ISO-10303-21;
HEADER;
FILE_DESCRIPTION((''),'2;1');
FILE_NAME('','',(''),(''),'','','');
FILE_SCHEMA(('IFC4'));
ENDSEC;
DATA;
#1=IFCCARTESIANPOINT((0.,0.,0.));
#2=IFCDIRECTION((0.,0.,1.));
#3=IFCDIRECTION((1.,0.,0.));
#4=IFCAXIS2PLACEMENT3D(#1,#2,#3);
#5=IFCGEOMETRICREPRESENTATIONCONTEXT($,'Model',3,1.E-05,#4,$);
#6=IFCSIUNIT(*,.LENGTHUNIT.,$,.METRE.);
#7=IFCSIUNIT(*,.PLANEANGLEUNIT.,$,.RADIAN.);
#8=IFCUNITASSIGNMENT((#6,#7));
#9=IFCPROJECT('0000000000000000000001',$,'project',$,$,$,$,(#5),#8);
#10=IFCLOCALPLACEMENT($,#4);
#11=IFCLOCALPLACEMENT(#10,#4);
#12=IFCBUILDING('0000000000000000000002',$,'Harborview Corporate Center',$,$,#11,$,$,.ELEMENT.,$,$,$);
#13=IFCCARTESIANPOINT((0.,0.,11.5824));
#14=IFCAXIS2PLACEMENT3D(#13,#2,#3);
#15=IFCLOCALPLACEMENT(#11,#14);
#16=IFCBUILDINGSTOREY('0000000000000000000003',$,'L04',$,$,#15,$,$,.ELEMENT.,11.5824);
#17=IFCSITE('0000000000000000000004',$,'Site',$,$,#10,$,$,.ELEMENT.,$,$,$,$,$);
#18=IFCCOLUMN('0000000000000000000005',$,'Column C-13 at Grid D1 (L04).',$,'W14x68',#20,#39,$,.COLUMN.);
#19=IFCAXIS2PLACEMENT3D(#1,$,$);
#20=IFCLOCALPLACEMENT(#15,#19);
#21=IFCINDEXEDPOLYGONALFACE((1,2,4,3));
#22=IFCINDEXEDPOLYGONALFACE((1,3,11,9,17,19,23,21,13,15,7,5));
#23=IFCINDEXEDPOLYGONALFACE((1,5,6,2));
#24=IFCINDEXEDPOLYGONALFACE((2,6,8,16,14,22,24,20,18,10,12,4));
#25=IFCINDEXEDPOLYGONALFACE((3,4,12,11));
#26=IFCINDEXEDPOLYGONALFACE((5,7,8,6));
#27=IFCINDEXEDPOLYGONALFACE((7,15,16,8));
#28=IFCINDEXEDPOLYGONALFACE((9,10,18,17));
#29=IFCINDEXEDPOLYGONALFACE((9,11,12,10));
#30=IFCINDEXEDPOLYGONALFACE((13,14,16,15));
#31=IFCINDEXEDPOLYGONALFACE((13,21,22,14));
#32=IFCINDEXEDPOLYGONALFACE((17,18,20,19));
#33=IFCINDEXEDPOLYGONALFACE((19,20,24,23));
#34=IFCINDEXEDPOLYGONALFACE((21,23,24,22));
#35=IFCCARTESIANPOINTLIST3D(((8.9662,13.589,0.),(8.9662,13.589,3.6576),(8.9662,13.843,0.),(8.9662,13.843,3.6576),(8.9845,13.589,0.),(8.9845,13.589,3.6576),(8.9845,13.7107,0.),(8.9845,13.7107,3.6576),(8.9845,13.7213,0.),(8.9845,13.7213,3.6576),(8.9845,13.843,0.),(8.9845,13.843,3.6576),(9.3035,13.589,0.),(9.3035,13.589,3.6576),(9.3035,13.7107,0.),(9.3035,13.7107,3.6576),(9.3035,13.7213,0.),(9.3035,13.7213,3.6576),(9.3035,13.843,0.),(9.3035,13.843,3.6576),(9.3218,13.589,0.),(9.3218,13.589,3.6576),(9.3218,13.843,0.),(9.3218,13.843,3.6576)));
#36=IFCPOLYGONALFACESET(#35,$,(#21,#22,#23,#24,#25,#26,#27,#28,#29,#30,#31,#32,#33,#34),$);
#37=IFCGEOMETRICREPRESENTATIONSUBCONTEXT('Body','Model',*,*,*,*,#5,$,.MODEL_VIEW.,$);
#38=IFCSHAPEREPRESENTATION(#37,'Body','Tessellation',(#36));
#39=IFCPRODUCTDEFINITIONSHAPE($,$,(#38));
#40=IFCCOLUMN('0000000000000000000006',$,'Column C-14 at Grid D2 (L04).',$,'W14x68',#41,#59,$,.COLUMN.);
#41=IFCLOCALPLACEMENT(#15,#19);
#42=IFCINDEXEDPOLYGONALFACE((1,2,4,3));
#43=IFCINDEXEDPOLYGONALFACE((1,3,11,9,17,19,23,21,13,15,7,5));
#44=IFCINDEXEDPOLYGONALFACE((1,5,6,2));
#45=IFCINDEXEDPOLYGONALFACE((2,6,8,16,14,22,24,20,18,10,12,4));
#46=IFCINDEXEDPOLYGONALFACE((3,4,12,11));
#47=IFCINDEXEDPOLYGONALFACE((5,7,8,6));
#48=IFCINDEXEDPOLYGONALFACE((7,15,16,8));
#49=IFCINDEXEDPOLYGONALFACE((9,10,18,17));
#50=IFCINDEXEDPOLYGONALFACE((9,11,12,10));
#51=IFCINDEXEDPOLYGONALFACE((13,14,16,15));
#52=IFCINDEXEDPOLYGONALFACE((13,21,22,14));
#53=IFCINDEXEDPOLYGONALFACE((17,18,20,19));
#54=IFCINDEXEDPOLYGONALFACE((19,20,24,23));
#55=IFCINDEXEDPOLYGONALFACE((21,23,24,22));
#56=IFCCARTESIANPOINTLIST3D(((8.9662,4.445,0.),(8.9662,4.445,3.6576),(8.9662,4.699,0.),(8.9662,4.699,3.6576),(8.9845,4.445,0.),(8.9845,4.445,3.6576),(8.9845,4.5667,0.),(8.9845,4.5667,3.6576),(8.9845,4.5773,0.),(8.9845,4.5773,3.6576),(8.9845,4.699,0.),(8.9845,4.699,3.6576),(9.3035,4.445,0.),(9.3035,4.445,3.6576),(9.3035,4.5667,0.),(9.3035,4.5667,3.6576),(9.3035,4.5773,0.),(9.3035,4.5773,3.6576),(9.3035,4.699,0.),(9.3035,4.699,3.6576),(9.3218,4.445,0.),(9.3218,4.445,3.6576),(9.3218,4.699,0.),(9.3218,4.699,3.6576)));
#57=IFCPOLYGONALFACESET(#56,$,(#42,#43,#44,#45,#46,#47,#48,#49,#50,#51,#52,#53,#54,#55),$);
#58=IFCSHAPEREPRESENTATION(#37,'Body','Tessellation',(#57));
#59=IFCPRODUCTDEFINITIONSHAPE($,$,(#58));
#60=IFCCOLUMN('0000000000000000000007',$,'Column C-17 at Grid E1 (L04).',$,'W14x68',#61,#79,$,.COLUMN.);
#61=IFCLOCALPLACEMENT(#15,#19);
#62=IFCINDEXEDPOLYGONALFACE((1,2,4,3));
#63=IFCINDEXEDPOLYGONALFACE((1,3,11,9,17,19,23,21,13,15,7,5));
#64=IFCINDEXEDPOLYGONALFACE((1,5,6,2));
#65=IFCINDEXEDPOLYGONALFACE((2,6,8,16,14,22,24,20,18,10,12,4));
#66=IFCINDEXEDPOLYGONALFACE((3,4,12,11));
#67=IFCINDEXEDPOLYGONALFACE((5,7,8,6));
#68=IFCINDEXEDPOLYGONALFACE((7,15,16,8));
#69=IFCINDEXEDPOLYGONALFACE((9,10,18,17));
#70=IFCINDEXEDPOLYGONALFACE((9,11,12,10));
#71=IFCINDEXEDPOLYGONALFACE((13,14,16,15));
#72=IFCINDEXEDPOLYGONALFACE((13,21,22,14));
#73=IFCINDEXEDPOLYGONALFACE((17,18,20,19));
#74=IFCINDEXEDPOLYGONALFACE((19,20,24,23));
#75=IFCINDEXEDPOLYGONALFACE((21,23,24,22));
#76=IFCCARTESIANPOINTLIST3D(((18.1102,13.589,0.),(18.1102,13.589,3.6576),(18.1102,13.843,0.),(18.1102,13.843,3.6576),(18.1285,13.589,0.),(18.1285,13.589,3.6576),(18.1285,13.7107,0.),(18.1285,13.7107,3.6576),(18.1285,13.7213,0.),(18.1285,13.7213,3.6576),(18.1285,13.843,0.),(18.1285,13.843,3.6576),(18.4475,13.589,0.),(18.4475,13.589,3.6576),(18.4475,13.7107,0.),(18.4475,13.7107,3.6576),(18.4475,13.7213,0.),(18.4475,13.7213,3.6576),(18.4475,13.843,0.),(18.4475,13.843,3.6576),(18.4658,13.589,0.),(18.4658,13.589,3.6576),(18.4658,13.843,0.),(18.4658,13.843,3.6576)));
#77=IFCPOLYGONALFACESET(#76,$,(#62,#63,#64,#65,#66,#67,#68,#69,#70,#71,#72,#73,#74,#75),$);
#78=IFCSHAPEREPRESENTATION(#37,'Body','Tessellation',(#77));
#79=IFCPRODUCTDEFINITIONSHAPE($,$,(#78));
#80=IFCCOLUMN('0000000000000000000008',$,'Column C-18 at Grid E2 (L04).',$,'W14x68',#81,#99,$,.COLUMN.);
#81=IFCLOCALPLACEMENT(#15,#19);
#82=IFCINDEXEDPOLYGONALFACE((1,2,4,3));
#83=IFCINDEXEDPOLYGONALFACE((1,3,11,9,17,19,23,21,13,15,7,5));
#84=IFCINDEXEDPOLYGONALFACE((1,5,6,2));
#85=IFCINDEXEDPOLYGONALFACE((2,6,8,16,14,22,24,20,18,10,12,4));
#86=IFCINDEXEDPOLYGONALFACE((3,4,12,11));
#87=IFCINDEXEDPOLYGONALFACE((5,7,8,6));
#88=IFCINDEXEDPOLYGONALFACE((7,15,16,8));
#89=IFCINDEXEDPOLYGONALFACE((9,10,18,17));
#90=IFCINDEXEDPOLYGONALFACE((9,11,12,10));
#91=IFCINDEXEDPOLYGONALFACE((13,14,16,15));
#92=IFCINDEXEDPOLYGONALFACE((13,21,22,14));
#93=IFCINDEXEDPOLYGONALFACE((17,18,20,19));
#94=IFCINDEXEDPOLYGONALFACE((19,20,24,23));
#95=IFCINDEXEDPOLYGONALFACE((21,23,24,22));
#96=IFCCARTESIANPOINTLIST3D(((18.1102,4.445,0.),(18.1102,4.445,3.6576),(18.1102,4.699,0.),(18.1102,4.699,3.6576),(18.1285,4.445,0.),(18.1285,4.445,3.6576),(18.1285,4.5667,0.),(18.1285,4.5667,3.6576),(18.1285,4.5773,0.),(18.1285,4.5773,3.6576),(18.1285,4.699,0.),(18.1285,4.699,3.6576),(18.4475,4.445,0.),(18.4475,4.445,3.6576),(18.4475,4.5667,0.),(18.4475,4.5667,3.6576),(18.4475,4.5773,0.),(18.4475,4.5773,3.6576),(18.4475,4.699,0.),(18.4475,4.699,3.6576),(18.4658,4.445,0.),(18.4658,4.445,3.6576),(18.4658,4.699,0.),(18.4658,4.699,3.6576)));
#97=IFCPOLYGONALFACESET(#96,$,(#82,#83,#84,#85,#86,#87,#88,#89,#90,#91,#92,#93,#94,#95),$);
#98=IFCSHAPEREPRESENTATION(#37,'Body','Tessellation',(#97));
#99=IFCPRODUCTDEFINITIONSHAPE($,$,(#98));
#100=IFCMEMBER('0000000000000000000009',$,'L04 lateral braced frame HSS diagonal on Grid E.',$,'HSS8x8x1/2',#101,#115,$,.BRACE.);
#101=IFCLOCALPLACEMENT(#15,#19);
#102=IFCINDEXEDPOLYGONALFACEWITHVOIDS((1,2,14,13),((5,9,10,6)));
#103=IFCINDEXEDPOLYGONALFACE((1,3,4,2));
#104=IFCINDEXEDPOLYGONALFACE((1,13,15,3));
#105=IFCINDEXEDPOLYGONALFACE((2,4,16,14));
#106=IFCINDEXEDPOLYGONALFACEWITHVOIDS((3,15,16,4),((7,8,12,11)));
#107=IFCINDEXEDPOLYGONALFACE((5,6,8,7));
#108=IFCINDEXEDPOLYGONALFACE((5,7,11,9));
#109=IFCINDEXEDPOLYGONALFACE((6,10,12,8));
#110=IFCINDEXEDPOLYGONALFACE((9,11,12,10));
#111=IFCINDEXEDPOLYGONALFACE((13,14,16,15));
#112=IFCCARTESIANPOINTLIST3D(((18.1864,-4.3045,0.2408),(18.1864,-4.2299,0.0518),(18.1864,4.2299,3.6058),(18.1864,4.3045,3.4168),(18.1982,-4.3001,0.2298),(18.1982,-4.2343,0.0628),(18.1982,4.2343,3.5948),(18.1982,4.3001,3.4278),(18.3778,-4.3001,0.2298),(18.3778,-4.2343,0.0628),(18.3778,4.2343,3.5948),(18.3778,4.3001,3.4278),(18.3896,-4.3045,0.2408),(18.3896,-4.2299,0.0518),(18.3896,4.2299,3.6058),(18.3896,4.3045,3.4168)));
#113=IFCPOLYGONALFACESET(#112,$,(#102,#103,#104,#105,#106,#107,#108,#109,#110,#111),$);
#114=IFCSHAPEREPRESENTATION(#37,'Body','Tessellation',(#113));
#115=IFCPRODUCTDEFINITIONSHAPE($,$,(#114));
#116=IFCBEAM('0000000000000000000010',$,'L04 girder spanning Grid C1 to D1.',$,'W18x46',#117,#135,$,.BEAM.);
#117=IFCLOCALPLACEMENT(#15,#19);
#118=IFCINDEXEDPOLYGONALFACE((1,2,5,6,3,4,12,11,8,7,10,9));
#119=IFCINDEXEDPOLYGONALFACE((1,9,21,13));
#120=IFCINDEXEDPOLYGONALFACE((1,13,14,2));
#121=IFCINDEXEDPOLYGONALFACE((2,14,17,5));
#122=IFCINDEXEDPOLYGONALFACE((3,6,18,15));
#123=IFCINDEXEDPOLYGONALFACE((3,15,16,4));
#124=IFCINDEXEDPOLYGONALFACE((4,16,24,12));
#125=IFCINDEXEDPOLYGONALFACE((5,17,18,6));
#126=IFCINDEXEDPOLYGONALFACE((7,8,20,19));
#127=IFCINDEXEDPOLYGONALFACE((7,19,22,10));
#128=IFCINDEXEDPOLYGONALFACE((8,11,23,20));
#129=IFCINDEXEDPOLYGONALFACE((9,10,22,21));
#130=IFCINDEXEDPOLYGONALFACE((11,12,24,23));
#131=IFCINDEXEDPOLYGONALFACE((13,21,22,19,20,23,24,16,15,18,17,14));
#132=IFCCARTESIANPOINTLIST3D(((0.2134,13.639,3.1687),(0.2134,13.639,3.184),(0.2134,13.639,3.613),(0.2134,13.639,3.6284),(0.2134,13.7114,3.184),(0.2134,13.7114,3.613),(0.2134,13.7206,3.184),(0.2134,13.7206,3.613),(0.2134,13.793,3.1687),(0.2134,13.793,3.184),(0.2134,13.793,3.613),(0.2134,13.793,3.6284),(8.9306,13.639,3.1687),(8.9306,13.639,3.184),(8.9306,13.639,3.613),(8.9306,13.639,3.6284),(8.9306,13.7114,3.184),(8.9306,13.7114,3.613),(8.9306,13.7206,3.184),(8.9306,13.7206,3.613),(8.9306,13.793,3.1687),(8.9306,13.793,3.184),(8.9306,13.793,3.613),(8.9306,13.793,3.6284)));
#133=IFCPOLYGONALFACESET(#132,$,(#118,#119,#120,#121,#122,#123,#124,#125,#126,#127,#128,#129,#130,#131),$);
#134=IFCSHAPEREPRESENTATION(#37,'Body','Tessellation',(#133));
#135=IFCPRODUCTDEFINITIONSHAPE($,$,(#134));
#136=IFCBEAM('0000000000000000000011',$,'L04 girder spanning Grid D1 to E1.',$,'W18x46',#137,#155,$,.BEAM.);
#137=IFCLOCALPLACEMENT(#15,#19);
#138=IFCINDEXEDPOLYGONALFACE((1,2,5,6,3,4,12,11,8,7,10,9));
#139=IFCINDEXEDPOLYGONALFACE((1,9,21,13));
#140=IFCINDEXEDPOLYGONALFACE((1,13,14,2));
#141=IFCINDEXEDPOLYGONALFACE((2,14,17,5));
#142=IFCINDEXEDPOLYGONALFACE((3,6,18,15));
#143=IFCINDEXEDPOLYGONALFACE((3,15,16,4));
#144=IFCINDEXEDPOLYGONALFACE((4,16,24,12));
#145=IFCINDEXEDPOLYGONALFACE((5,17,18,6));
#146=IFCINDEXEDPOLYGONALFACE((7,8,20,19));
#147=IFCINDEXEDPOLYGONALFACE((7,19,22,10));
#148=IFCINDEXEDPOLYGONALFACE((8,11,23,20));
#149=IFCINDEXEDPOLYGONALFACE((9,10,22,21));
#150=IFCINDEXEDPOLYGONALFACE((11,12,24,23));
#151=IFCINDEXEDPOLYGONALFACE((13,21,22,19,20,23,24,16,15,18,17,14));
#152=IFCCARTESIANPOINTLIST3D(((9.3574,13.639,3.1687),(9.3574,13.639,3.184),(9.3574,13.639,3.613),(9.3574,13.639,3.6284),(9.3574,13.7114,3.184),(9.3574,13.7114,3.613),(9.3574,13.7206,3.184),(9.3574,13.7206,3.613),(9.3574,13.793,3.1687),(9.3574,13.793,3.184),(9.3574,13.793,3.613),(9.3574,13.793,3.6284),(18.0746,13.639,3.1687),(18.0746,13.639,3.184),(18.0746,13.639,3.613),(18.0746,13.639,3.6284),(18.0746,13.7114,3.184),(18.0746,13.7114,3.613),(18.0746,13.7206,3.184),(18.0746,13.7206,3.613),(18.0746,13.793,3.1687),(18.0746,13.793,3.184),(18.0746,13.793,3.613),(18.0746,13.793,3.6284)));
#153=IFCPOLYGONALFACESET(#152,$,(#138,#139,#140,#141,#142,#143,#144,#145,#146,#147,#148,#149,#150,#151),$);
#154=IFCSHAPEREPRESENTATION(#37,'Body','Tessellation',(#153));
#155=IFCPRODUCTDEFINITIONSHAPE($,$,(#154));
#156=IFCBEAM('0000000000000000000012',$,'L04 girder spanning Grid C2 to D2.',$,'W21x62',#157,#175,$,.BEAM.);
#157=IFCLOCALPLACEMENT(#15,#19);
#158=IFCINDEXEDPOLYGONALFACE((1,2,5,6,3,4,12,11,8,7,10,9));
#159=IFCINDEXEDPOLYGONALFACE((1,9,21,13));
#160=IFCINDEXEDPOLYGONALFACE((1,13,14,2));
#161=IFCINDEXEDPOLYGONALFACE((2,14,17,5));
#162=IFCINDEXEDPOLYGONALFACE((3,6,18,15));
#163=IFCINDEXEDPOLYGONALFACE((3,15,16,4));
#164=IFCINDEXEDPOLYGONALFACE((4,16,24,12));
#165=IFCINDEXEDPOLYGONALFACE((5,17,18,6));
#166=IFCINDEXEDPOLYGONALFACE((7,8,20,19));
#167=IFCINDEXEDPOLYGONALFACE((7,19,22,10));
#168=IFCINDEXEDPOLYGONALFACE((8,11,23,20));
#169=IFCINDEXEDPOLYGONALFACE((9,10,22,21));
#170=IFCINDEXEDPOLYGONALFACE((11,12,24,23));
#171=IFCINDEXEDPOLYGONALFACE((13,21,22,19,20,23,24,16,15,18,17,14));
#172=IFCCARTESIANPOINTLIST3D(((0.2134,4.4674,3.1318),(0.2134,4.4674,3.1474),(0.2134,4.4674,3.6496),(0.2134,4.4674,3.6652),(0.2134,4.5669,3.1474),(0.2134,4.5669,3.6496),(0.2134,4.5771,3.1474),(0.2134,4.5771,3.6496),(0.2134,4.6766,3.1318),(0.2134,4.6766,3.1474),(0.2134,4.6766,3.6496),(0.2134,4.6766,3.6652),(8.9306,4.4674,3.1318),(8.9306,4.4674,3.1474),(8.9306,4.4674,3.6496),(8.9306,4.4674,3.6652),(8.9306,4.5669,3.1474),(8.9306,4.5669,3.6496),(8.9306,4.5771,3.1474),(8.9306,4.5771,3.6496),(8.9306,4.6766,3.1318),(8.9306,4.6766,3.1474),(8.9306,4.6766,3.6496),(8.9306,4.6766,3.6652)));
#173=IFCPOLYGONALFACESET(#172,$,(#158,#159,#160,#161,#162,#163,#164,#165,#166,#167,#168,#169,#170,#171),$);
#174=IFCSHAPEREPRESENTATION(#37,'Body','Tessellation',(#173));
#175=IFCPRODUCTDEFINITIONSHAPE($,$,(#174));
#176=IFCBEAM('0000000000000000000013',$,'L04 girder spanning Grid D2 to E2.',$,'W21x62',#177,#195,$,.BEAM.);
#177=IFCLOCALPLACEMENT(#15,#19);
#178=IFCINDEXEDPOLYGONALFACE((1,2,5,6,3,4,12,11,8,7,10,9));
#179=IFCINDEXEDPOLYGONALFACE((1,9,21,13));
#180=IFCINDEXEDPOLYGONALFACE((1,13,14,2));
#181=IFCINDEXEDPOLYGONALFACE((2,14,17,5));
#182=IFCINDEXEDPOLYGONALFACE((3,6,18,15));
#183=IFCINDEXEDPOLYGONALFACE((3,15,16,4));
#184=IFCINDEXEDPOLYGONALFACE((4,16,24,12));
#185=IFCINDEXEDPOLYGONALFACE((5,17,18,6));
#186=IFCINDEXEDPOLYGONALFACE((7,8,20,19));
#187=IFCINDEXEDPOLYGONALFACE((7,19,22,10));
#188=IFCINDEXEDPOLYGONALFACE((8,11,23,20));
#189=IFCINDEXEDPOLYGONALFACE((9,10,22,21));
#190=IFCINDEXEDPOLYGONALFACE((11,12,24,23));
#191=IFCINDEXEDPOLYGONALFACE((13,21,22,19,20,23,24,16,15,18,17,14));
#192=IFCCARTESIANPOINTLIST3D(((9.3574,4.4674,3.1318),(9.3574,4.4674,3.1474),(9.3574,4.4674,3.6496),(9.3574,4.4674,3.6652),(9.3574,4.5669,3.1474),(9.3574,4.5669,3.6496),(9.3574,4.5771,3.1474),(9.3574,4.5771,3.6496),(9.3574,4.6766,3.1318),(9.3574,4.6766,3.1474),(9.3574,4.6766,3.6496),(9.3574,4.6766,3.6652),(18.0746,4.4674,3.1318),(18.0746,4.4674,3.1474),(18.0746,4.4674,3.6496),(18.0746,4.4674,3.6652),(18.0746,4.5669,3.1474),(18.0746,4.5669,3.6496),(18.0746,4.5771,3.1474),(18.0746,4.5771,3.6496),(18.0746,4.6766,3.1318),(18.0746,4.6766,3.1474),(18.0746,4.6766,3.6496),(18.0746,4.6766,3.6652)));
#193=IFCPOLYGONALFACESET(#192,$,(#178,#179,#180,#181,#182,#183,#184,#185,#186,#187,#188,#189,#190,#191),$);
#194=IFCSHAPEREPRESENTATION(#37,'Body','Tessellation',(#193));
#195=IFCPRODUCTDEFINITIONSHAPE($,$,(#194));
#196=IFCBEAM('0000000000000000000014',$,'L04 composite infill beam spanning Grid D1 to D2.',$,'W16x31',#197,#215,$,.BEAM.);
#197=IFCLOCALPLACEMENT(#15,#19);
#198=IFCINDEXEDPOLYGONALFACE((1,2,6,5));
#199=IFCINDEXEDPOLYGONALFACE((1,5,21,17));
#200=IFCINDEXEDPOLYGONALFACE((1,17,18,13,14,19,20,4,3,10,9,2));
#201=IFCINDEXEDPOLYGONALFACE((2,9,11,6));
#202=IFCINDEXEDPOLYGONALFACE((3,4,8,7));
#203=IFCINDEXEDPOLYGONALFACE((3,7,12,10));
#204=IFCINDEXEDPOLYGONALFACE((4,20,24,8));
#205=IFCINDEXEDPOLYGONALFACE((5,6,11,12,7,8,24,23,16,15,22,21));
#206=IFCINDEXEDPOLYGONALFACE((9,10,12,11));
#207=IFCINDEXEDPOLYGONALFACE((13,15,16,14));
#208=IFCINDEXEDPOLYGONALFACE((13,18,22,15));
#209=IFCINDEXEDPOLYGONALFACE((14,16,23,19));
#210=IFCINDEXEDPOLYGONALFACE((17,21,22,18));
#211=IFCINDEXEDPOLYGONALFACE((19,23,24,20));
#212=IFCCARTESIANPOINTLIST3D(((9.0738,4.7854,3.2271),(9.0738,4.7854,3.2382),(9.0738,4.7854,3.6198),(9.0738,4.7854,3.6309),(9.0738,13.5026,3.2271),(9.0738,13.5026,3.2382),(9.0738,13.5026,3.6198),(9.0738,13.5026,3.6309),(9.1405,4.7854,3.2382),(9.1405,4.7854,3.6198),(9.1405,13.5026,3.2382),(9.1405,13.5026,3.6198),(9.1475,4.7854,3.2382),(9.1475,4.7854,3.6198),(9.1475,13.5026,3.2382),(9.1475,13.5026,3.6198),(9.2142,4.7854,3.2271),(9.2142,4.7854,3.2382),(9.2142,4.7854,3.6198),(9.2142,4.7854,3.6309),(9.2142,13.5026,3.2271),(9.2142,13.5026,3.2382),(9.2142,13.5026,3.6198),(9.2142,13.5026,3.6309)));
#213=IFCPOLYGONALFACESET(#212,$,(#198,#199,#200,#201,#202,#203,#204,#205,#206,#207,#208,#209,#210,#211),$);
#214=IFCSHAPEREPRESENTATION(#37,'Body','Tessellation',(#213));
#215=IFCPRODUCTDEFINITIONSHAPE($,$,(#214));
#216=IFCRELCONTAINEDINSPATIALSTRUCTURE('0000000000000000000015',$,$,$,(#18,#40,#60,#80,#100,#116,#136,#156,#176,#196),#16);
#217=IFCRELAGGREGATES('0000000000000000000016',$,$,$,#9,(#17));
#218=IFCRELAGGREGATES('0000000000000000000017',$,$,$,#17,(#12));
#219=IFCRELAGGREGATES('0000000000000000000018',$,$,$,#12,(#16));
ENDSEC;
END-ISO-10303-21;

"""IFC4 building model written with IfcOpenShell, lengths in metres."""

from ifc_helpers import new_model, si_unit, frame, origin_with_axes, place, context, subcontext, project, spatial, hollow_rectangle, i_section, extrude, element, save


model = new_model("IFC4")

# Units and contexts
model_context = context("Model", 3, precision=1e-05, world=origin_with_axes())
body_context = subcontext(model_context, "Body", "Model", "MODEL_VIEW")
ifc_project = project(units=[si_unit("LENGTHUNIT", "METRE"), si_unit("PLANEANGLEUNIT", "RADIAN")], contexts=[model_context])

# Site, building, storey
site_placement = place(None, origin_with_axes())
site = spatial("IfcSite", under=ifc_project, at=site_placement, Name="Site", CompositionType="ELEMENT")
building_placement = place(site_placement, origin_with_axes())
building = spatial("IfcBuilding", under=site, at=building_placement, Name="Harborview Corporate Center", CompositionType="ELEMENT")
storey_placement = place(building_placement, frame((0.0, 0.0, 11.5824), z_axis=(0.0, 0.0, 1.0), x_axis=(1.0, 0.0, 0.0)))
storey = spatial("IfcBuildingStorey", under=building, at=storey_placement, Name="L04", CompositionType="ELEMENT", Elevation=11.5824)

# Columns
for number, where, z_axis, x_axis, name in (
    (1, (9.144, 13.716, 0.0), (0.0, 0.0, 1.0), (0.0, 1.0, 0.0), "Column C-13 at Grid D1 (L04)."),
    (2, (9.144, 4.572, 0.0), (0.0, 0.0, 1.0), (0.0, 1.0, 0.0), "Column C-14 at Grid D2 (L04)."),
    (3, (18.288, 13.716, 0.0), (0.0, 0.0, 1.0), (0.0, 1.0, 0.0), "Column C-17 at Grid E1 (L04)."),
    (4, (18.288, 4.572, 0.0), (0.0, 0.0, 1.0), (0.0, 1.0, 0.0), "Column C-18 at Grid E2 (L04)."),
):
    element("IfcColumn", number, at=place(storey_placement, frame(where, z_axis=z_axis, x_axis=x_axis)), inside=storey, Name=name, ObjectType="W14x68", PredefinedType="COLUMN", context=body_context, shape_type="SweptSolid", body=[
        extrude(i_section(OverallWidth=0.254, OverallDepth=0.3556, WebThickness=0.0105, FlangeThickness=0.0183), origin_with_axes(), (0.0, 0.0, 1.0), 3.6576),
    ])

# Member
member_placement = place(storey_placement, frame((18.288, -4.2672, 0.1463), z_axis=(0.0, 0.930298, 0.366803), x_axis=(-1.0, 0.0, 0.0)))
element("IfcMember", 5, at=member_placement, inside=storey, Name="L04 lateral braced frame HSS diagonal on Grid E.", ObjectType="HSS8x8x1/2", PredefinedType="BRACE", context=body_context, shape_type="SweptSolid", body=[
    extrude(hollow_rectangle(XDim=0.2032, YDim=0.2032, WallThickness=0.0118), origin_with_axes(), (0.0, 0.0, 1.0), 9.1738),
])

# Beams
beam_1_placement = place(storey_placement, frame((0.2134, 13.716, 3.3985), z_axis=(1.0, 0.0, 0.0), x_axis=(0.0, 1.0, 0.0)))
element("IfcBeam", 6, at=beam_1_placement, inside=storey, Name="L04 girder spanning Grid C1 to D1.", ObjectType="W18x46", PredefinedType="BEAM", context=body_context, shape_type="SweptSolid", body=[
    extrude(i_section(OverallWidth=0.1539, OverallDepth=0.4597, WebThickness=0.0091, FlangeThickness=0.0154), origin_with_axes(), (0.0, 0.0, 1.0), 8.7173),
])
beam_2_placement = place(storey_placement, frame((9.3574, 13.716, 3.3985), z_axis=(1.0, 0.0, 0.0), x_axis=(0.0, 1.0, 0.0)))
element("IfcBeam", 7, at=beam_2_placement, inside=storey, Name="L04 girder spanning Grid D1 to E1.", ObjectType="W18x46", PredefinedType="BEAM", context=body_context, shape_type="SweptSolid", body=[
    extrude(i_section(OverallWidth=0.1539, OverallDepth=0.4597, WebThickness=0.0091, FlangeThickness=0.0154), origin_with_axes(), (0.0, 0.0, 1.0), 8.7173),
])
beam_3_placement = place(storey_placement, frame((0.2134, 4.572, 3.3985), z_axis=(1.0, 0.0, 0.0), x_axis=(0.0, 1.0, 0.0)))
element("IfcBeam", 8, at=beam_3_placement, inside=storey, Name="L04 girder spanning Grid C2 to D2.", ObjectType="W21x62", PredefinedType="BEAM", context=body_context, shape_type="SweptSolid", body=[
    extrude(i_section(OverallWidth=0.2093, OverallDepth=0.5334, WebThickness=0.0102, FlangeThickness=0.0156), origin_with_axes(), (0.0, 0.0, 1.0), 8.7173),
])
beam_4_placement = place(storey_placement, frame((9.3574, 4.572, 3.3985), z_axis=(1.0, 0.0, 0.0), x_axis=(0.0, 1.0, 0.0)))
element("IfcBeam", 9, at=beam_4_placement, inside=storey, Name="L04 girder spanning Grid D2 to E2.", ObjectType="W21x62", PredefinedType="BEAM", context=body_context, shape_type="SweptSolid", body=[
    extrude(i_section(OverallWidth=0.2093, OverallDepth=0.5334, WebThickness=0.0102, FlangeThickness=0.0156), origin_with_axes(), (0.0, 0.0, 1.0), 8.7173),
])
for number, where, z_axis, x_axis, name in (
    (10, (9.144, 4.7854, 3.429), (0.0, 1.0, 0.0), (-1.0, 0.0, 0.0), "L04 composite infill beam spanning Grid D1 to D2."),
):
    element("IfcBeam", number, at=place(storey_placement, frame(where, z_axis=z_axis, x_axis=x_axis)), inside=storey, Name=name, ObjectType="W16x31", PredefinedType="BEAM", context=body_context, shape_type="SweptSolid", body=[
        extrude(i_section(OverallWidth=0.1405, OverallDepth=0.4039, WebThickness=0.007, FlangeThickness=0.0112), origin_with_axes(), (0.0, 0.0, 1.0), 8.7173),
    ])

save(model, "model.ifc")
